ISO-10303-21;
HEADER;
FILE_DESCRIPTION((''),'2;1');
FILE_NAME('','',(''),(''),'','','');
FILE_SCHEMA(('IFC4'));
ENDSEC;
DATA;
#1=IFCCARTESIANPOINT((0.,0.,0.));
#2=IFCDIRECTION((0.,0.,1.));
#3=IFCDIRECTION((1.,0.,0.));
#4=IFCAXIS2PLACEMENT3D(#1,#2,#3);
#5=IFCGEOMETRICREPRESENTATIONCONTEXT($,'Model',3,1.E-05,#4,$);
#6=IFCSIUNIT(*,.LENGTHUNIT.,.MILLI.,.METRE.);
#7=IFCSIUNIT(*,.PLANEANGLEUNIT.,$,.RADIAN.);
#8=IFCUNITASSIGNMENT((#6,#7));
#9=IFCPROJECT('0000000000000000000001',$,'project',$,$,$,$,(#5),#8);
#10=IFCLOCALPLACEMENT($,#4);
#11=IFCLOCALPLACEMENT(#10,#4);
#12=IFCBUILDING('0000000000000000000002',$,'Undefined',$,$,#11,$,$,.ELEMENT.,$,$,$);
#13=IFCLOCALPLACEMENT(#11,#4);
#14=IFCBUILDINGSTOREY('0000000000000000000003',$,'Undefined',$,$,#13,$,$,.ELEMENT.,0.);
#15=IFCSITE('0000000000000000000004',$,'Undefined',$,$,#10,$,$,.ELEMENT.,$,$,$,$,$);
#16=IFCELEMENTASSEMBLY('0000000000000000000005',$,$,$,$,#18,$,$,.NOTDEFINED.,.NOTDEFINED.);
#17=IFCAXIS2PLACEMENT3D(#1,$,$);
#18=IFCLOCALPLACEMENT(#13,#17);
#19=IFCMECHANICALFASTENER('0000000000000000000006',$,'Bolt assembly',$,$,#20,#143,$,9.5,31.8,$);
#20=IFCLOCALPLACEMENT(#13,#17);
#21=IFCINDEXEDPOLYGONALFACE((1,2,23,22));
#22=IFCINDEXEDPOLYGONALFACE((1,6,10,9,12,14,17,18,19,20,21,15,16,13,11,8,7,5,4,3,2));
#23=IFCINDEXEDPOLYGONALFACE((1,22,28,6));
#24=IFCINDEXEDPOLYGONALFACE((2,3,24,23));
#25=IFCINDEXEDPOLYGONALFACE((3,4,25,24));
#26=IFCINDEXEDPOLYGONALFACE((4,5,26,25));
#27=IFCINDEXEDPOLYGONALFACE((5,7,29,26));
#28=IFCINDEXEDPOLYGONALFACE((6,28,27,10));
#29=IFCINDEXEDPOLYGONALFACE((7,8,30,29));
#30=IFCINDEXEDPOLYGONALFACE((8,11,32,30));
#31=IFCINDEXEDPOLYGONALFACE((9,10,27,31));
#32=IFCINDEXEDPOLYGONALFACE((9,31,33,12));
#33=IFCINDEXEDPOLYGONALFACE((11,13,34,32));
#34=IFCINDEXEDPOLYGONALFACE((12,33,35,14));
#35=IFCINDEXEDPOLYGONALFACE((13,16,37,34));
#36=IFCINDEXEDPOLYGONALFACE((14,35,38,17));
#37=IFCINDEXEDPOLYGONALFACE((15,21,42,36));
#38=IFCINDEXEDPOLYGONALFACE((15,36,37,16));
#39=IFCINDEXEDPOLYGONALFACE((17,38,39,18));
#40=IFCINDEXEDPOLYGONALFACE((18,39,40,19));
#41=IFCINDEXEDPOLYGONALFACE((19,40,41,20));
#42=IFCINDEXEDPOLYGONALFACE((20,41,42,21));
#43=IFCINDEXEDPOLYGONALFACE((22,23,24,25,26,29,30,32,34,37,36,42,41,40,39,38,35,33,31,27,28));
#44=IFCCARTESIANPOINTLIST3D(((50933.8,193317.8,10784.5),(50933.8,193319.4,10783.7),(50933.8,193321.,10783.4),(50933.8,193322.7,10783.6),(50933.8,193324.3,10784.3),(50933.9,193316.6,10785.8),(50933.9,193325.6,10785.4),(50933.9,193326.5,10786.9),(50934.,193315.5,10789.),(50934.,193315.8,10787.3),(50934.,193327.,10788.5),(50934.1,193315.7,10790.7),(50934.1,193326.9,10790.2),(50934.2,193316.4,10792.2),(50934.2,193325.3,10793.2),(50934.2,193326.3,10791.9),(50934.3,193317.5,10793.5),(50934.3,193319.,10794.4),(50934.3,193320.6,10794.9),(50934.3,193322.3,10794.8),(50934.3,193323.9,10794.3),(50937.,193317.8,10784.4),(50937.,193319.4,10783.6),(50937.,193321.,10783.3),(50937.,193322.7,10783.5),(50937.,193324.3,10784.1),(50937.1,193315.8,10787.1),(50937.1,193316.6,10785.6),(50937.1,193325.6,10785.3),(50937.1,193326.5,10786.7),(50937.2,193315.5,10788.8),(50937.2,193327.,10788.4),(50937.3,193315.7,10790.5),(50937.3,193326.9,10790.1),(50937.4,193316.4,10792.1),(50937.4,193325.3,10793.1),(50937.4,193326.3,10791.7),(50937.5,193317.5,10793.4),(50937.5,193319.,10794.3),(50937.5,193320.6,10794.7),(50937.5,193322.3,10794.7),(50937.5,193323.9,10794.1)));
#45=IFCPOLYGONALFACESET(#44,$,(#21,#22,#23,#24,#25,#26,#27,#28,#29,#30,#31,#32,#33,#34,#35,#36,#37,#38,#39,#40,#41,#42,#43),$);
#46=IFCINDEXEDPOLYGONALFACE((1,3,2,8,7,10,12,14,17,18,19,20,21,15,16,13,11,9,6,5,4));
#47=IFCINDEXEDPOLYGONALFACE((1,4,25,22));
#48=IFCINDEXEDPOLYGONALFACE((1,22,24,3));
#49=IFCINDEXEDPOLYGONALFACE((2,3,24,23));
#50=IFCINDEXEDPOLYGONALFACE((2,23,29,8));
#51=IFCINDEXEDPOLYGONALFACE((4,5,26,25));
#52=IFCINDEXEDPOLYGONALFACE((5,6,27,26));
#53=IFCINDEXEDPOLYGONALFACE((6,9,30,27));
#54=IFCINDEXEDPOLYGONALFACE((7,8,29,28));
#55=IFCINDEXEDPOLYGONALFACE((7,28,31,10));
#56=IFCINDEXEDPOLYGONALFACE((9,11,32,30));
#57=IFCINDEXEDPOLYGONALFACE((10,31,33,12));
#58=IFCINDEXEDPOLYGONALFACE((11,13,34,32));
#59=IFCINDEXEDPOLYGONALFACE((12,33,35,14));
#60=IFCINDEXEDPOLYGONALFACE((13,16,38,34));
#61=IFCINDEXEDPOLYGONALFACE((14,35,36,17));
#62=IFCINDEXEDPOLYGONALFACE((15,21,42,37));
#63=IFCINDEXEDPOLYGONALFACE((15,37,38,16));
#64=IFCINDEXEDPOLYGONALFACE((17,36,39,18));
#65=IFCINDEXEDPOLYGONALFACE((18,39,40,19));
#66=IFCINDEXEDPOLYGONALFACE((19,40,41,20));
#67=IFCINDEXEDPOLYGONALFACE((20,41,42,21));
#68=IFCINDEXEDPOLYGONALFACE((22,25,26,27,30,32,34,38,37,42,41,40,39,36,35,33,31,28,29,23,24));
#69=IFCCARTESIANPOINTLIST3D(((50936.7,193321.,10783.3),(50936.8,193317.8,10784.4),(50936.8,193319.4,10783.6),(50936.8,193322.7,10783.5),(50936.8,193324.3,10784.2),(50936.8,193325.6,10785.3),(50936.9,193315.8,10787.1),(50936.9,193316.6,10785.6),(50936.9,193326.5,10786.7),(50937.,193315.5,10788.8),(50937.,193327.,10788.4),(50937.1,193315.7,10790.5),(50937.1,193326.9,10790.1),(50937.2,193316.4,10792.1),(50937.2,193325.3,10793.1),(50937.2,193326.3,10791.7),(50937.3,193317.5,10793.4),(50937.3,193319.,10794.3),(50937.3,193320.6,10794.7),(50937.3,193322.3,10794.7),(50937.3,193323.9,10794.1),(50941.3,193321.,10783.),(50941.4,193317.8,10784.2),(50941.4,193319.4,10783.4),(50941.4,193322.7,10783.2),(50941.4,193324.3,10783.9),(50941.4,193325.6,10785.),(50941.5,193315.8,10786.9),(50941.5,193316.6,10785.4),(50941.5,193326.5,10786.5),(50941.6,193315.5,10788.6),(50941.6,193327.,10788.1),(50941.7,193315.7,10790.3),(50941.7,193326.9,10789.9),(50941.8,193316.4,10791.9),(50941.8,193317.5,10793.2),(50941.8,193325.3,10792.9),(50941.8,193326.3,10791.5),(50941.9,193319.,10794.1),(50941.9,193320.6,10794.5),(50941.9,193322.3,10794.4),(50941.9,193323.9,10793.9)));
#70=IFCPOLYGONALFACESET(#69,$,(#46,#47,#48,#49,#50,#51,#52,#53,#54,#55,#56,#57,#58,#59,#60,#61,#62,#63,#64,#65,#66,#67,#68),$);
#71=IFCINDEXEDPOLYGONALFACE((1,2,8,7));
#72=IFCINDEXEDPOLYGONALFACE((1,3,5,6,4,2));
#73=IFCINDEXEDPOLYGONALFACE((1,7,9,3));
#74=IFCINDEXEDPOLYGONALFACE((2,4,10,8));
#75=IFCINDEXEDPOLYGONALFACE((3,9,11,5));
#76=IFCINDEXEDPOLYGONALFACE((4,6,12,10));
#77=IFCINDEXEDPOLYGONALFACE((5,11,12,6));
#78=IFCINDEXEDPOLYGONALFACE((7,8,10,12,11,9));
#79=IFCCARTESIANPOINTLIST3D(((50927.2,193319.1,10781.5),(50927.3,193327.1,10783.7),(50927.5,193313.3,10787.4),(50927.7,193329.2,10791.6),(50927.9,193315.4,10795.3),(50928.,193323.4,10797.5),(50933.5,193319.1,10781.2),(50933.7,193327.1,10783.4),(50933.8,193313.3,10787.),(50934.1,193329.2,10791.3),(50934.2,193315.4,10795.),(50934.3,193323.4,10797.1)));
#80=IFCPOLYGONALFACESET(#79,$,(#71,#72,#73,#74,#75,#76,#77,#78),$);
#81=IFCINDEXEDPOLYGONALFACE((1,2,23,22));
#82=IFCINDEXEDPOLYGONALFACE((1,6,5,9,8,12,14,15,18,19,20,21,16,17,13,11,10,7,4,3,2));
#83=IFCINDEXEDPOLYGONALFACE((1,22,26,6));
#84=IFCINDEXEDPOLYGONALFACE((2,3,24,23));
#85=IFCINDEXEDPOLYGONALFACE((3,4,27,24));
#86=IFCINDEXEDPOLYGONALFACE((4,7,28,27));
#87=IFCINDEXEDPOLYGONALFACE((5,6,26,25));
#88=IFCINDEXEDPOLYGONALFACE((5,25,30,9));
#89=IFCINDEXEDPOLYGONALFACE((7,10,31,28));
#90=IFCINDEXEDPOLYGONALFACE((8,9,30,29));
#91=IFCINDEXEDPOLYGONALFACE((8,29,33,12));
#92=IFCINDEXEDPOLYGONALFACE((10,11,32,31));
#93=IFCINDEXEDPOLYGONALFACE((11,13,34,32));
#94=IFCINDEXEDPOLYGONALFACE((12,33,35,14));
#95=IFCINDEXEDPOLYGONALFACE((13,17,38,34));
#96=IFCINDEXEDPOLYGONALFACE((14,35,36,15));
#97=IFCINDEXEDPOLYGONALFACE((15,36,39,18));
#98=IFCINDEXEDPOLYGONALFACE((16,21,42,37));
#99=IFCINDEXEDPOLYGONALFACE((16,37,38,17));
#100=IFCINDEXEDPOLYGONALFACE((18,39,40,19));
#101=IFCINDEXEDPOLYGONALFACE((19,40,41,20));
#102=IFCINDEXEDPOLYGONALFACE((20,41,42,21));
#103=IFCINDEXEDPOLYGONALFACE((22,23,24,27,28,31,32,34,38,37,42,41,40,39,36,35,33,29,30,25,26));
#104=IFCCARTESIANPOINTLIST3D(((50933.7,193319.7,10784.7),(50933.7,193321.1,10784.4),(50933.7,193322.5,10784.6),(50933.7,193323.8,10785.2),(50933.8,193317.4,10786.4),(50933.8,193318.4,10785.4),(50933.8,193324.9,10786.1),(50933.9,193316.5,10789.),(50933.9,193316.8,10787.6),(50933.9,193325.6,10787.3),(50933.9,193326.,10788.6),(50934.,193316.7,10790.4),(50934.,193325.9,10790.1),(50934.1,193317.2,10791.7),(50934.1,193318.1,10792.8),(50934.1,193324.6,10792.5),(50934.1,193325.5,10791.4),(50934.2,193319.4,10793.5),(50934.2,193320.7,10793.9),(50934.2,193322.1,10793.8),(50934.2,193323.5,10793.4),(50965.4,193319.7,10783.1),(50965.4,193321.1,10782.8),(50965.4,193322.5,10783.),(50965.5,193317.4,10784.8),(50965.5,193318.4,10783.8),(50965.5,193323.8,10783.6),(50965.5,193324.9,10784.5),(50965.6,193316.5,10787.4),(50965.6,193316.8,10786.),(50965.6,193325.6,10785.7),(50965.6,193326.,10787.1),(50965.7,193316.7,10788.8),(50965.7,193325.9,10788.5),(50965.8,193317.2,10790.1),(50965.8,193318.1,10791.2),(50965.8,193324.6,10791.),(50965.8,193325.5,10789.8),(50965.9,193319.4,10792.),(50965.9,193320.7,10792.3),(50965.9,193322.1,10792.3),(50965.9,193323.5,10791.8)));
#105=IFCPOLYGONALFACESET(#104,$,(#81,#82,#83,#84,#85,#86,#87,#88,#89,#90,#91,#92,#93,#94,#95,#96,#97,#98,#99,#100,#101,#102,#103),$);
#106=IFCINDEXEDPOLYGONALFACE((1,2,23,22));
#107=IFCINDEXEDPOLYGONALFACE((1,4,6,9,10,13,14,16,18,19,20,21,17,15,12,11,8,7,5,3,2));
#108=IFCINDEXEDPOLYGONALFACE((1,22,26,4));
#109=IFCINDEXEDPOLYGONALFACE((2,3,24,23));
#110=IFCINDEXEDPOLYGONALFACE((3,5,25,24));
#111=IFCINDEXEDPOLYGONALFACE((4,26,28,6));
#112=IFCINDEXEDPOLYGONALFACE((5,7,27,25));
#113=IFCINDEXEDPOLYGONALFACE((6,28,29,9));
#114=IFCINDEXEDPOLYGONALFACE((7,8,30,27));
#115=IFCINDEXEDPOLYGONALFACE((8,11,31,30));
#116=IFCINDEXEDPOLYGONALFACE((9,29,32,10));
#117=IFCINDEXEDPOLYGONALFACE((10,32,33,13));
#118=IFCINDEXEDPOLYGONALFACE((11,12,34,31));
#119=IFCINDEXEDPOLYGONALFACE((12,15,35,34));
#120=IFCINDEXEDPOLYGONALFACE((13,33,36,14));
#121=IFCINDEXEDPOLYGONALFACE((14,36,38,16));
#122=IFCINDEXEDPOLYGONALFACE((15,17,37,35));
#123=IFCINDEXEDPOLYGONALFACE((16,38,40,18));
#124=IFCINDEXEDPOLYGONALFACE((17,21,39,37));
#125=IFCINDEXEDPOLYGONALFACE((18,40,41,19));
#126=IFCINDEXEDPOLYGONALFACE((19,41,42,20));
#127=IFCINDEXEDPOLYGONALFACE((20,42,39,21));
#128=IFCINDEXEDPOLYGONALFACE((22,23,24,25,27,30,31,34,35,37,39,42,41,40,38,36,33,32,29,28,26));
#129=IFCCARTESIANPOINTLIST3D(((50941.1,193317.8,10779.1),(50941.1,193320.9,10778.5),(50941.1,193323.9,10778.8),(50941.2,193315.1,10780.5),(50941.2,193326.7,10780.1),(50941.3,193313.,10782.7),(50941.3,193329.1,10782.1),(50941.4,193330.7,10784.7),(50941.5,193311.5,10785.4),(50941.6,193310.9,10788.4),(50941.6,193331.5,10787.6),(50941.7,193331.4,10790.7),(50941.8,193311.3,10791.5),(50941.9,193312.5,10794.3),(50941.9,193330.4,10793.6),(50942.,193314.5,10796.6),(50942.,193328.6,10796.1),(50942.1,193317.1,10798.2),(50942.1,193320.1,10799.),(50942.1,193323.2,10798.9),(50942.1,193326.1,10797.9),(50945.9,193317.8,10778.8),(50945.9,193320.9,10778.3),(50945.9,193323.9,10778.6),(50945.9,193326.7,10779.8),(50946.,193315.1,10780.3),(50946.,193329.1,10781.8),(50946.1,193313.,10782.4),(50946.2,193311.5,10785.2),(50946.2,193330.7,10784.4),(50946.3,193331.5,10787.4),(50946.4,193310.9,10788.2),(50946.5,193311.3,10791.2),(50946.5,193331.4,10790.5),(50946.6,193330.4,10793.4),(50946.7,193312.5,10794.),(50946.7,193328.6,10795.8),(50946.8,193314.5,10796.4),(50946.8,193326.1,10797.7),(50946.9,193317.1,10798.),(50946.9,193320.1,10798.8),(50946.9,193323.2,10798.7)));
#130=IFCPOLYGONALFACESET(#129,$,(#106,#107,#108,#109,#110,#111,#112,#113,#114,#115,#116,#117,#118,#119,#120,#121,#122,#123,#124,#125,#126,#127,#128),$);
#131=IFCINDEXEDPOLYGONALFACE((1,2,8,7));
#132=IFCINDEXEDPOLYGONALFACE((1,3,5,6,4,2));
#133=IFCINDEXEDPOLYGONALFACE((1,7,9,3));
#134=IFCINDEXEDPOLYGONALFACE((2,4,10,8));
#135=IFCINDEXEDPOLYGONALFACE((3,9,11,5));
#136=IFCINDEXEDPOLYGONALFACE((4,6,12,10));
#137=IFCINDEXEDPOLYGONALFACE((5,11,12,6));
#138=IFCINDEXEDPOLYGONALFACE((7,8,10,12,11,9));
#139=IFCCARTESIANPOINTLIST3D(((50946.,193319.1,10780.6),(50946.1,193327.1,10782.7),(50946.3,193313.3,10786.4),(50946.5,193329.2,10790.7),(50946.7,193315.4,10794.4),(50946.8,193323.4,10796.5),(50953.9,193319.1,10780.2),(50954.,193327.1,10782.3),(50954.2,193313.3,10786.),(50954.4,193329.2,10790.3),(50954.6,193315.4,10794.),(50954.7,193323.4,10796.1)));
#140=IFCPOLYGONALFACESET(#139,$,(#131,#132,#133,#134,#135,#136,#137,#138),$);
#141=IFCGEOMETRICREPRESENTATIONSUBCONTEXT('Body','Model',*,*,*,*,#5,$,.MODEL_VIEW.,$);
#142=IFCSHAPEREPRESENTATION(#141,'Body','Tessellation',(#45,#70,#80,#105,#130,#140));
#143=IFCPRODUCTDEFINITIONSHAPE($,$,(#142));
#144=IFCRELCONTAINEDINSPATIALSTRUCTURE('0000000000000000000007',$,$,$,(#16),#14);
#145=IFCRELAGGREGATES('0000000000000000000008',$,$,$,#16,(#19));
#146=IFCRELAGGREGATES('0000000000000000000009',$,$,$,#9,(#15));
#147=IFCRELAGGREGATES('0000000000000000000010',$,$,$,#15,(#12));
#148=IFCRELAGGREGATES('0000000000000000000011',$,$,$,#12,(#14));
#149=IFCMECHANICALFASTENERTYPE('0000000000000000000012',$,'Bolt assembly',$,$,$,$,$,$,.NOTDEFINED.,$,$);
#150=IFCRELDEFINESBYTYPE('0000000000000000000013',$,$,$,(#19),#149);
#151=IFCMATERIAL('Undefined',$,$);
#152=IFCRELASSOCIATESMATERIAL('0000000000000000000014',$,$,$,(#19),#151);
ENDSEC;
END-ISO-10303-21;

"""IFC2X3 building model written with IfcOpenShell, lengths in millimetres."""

from ifc_helpers import new_model, si_unit, frame, origin_with_axes, origin_2d_with_axis, place, context, subcontext, project, spatial, polyline, circle, outline, extrude, source, transform, mapped, material, type_object, element, aggregate, save


model = new_model("IFC2X3")

# Units and contexts
model_context = context("Model", 3, precision=1e-05, world=origin_with_axes())
body_context = subcontext(model_context, "Body", "Model", "MODEL_VIEW")
ifc_project = project(units=[si_unit("LENGTHUNIT", "METRE", prefix="MILLI"), si_unit("PLANEANGLEUNIT", "RADIAN")], contexts=[model_context])

# Site, building, storey
site_placement = place(None, origin_with_axes())
site = spatial("IfcSite", under=ifc_project, at=site_placement, Name="Undefined", CompositionType="ELEMENT")
building_placement = place(site_placement, origin_with_axes())
building = spatial("IfcBuilding", under=site, at=building_placement, Name="Undefined", CompositionType="ELEMENT")
storey_placement = place(building_placement, origin_with_axes())
storey = spatial("IfcBuildingStorey", under=building, at=storey_placement, Name="Undefined", CompositionType="ELEMENT", Elevation=0.0)

# Element assembly
assembly_1_placement = place(storey_placement, origin_with_axes())
assembly_1 = element("IfcElementAssembly", 1, at=assembly_1_placement, inside=storey, AssemblyPlace="NOTDEFINED", PredefinedType="NOTDEFINED")

# Mechanical fastener
ifc_material_1 = material(Name="Undefined")
mechanical_fastener_type = type_object("IfcMechanicalFastenerType", Name="Bolt assembly")
shared_shape_1 = source(origin_with_axes(), body_context, "Body", "SweptSolid", [
    extrude(circle(Radius=5.8, at=origin_2d_with_axis()), frame((0.0, -7.6, 0.0), z_axis=(0.0, 1.0, 0.0), x_axis=(1.0, 0.0, 0.0)), (0.0, 0.0, 1.0), 3.2),
    extrude(circle(Radius=5.8, at=origin_2d_with_axis()), frame((0.0, -4.6, 0.0), z_axis=(0.0, 1.0, 0.0), x_axis=(1.0, 0.0, 0.0)), (0.0, 0.0, 1.0), 4.6),
    extrude(outline(polyline([(7.1, -4.1), (7.1, 4.1), (0.0, 8.2), (-7.1, 4.1), (-7.1, -4.1), (0.0, -8.2), (7.1, -4.1)])), frame((0.0, -14.0, 0.0), z_axis=(0.0, 1.0, 0.0), x_axis=(1.0, 0.0, 0.0)), (0.0, 0.0, 1.0), 6.3),
    extrude(circle(Radius=4.8, at=origin_2d_with_axis()), frame((0.0, -7.7, 0.0), z_axis=(0.0, 1.0, 0.0), x_axis=(1.0, 0.0, 0.0)), (0.0, 0.0, 1.0), 31.8),
    extrude(circle(Radius=10.3, at=origin_2d_with_axis()), frame((0.0, 0.0, 0.0), z_axis=(0.0, 1.0, 0.0), x_axis=(1.0, 0.0, 0.0)), (0.0, 0.0, 1.0), 4.8),
    extrude(outline(polyline([(7.1, -4.1), (7.1, 4.1), (0.0, 8.2), (-7.1, 4.1), (-7.1, -4.1), (0.0, -8.2), (7.1, -4.1)])), frame((0.0, 4.8, 0.0), z_axis=(0.0, 1.0, 0.0), x_axis=(1.0, 0.0, 0.0)), (0.0, 0.0, 1.0), 7.9),
])
mechanical_fastener_1_placement = place(assembly_1_placement, frame((50941.6, 193321.3, 10788.8), z_axis=(-0.035282, 0.707107, -0.706226), x_axis=(0.035281, 0.707107, 0.706226)))
mechanical_fastener_1 = element("IfcMechanicalFastener", 2, at=mechanical_fastener_1_placement, type_object=mechanical_fastener_type, material=ifc_material_1, Name="Bolt assembly", NominalDiameter=9.5, NominalLength=31.8, context=body_context, shape_type="MappedRepresentation", body=[
    mapped(shared_shape_1, transform((0.0, 0.0, 0.0))),
])
aggregate(assembly_1, [mechanical_fastener_1])

save(model, "model.ifc")
